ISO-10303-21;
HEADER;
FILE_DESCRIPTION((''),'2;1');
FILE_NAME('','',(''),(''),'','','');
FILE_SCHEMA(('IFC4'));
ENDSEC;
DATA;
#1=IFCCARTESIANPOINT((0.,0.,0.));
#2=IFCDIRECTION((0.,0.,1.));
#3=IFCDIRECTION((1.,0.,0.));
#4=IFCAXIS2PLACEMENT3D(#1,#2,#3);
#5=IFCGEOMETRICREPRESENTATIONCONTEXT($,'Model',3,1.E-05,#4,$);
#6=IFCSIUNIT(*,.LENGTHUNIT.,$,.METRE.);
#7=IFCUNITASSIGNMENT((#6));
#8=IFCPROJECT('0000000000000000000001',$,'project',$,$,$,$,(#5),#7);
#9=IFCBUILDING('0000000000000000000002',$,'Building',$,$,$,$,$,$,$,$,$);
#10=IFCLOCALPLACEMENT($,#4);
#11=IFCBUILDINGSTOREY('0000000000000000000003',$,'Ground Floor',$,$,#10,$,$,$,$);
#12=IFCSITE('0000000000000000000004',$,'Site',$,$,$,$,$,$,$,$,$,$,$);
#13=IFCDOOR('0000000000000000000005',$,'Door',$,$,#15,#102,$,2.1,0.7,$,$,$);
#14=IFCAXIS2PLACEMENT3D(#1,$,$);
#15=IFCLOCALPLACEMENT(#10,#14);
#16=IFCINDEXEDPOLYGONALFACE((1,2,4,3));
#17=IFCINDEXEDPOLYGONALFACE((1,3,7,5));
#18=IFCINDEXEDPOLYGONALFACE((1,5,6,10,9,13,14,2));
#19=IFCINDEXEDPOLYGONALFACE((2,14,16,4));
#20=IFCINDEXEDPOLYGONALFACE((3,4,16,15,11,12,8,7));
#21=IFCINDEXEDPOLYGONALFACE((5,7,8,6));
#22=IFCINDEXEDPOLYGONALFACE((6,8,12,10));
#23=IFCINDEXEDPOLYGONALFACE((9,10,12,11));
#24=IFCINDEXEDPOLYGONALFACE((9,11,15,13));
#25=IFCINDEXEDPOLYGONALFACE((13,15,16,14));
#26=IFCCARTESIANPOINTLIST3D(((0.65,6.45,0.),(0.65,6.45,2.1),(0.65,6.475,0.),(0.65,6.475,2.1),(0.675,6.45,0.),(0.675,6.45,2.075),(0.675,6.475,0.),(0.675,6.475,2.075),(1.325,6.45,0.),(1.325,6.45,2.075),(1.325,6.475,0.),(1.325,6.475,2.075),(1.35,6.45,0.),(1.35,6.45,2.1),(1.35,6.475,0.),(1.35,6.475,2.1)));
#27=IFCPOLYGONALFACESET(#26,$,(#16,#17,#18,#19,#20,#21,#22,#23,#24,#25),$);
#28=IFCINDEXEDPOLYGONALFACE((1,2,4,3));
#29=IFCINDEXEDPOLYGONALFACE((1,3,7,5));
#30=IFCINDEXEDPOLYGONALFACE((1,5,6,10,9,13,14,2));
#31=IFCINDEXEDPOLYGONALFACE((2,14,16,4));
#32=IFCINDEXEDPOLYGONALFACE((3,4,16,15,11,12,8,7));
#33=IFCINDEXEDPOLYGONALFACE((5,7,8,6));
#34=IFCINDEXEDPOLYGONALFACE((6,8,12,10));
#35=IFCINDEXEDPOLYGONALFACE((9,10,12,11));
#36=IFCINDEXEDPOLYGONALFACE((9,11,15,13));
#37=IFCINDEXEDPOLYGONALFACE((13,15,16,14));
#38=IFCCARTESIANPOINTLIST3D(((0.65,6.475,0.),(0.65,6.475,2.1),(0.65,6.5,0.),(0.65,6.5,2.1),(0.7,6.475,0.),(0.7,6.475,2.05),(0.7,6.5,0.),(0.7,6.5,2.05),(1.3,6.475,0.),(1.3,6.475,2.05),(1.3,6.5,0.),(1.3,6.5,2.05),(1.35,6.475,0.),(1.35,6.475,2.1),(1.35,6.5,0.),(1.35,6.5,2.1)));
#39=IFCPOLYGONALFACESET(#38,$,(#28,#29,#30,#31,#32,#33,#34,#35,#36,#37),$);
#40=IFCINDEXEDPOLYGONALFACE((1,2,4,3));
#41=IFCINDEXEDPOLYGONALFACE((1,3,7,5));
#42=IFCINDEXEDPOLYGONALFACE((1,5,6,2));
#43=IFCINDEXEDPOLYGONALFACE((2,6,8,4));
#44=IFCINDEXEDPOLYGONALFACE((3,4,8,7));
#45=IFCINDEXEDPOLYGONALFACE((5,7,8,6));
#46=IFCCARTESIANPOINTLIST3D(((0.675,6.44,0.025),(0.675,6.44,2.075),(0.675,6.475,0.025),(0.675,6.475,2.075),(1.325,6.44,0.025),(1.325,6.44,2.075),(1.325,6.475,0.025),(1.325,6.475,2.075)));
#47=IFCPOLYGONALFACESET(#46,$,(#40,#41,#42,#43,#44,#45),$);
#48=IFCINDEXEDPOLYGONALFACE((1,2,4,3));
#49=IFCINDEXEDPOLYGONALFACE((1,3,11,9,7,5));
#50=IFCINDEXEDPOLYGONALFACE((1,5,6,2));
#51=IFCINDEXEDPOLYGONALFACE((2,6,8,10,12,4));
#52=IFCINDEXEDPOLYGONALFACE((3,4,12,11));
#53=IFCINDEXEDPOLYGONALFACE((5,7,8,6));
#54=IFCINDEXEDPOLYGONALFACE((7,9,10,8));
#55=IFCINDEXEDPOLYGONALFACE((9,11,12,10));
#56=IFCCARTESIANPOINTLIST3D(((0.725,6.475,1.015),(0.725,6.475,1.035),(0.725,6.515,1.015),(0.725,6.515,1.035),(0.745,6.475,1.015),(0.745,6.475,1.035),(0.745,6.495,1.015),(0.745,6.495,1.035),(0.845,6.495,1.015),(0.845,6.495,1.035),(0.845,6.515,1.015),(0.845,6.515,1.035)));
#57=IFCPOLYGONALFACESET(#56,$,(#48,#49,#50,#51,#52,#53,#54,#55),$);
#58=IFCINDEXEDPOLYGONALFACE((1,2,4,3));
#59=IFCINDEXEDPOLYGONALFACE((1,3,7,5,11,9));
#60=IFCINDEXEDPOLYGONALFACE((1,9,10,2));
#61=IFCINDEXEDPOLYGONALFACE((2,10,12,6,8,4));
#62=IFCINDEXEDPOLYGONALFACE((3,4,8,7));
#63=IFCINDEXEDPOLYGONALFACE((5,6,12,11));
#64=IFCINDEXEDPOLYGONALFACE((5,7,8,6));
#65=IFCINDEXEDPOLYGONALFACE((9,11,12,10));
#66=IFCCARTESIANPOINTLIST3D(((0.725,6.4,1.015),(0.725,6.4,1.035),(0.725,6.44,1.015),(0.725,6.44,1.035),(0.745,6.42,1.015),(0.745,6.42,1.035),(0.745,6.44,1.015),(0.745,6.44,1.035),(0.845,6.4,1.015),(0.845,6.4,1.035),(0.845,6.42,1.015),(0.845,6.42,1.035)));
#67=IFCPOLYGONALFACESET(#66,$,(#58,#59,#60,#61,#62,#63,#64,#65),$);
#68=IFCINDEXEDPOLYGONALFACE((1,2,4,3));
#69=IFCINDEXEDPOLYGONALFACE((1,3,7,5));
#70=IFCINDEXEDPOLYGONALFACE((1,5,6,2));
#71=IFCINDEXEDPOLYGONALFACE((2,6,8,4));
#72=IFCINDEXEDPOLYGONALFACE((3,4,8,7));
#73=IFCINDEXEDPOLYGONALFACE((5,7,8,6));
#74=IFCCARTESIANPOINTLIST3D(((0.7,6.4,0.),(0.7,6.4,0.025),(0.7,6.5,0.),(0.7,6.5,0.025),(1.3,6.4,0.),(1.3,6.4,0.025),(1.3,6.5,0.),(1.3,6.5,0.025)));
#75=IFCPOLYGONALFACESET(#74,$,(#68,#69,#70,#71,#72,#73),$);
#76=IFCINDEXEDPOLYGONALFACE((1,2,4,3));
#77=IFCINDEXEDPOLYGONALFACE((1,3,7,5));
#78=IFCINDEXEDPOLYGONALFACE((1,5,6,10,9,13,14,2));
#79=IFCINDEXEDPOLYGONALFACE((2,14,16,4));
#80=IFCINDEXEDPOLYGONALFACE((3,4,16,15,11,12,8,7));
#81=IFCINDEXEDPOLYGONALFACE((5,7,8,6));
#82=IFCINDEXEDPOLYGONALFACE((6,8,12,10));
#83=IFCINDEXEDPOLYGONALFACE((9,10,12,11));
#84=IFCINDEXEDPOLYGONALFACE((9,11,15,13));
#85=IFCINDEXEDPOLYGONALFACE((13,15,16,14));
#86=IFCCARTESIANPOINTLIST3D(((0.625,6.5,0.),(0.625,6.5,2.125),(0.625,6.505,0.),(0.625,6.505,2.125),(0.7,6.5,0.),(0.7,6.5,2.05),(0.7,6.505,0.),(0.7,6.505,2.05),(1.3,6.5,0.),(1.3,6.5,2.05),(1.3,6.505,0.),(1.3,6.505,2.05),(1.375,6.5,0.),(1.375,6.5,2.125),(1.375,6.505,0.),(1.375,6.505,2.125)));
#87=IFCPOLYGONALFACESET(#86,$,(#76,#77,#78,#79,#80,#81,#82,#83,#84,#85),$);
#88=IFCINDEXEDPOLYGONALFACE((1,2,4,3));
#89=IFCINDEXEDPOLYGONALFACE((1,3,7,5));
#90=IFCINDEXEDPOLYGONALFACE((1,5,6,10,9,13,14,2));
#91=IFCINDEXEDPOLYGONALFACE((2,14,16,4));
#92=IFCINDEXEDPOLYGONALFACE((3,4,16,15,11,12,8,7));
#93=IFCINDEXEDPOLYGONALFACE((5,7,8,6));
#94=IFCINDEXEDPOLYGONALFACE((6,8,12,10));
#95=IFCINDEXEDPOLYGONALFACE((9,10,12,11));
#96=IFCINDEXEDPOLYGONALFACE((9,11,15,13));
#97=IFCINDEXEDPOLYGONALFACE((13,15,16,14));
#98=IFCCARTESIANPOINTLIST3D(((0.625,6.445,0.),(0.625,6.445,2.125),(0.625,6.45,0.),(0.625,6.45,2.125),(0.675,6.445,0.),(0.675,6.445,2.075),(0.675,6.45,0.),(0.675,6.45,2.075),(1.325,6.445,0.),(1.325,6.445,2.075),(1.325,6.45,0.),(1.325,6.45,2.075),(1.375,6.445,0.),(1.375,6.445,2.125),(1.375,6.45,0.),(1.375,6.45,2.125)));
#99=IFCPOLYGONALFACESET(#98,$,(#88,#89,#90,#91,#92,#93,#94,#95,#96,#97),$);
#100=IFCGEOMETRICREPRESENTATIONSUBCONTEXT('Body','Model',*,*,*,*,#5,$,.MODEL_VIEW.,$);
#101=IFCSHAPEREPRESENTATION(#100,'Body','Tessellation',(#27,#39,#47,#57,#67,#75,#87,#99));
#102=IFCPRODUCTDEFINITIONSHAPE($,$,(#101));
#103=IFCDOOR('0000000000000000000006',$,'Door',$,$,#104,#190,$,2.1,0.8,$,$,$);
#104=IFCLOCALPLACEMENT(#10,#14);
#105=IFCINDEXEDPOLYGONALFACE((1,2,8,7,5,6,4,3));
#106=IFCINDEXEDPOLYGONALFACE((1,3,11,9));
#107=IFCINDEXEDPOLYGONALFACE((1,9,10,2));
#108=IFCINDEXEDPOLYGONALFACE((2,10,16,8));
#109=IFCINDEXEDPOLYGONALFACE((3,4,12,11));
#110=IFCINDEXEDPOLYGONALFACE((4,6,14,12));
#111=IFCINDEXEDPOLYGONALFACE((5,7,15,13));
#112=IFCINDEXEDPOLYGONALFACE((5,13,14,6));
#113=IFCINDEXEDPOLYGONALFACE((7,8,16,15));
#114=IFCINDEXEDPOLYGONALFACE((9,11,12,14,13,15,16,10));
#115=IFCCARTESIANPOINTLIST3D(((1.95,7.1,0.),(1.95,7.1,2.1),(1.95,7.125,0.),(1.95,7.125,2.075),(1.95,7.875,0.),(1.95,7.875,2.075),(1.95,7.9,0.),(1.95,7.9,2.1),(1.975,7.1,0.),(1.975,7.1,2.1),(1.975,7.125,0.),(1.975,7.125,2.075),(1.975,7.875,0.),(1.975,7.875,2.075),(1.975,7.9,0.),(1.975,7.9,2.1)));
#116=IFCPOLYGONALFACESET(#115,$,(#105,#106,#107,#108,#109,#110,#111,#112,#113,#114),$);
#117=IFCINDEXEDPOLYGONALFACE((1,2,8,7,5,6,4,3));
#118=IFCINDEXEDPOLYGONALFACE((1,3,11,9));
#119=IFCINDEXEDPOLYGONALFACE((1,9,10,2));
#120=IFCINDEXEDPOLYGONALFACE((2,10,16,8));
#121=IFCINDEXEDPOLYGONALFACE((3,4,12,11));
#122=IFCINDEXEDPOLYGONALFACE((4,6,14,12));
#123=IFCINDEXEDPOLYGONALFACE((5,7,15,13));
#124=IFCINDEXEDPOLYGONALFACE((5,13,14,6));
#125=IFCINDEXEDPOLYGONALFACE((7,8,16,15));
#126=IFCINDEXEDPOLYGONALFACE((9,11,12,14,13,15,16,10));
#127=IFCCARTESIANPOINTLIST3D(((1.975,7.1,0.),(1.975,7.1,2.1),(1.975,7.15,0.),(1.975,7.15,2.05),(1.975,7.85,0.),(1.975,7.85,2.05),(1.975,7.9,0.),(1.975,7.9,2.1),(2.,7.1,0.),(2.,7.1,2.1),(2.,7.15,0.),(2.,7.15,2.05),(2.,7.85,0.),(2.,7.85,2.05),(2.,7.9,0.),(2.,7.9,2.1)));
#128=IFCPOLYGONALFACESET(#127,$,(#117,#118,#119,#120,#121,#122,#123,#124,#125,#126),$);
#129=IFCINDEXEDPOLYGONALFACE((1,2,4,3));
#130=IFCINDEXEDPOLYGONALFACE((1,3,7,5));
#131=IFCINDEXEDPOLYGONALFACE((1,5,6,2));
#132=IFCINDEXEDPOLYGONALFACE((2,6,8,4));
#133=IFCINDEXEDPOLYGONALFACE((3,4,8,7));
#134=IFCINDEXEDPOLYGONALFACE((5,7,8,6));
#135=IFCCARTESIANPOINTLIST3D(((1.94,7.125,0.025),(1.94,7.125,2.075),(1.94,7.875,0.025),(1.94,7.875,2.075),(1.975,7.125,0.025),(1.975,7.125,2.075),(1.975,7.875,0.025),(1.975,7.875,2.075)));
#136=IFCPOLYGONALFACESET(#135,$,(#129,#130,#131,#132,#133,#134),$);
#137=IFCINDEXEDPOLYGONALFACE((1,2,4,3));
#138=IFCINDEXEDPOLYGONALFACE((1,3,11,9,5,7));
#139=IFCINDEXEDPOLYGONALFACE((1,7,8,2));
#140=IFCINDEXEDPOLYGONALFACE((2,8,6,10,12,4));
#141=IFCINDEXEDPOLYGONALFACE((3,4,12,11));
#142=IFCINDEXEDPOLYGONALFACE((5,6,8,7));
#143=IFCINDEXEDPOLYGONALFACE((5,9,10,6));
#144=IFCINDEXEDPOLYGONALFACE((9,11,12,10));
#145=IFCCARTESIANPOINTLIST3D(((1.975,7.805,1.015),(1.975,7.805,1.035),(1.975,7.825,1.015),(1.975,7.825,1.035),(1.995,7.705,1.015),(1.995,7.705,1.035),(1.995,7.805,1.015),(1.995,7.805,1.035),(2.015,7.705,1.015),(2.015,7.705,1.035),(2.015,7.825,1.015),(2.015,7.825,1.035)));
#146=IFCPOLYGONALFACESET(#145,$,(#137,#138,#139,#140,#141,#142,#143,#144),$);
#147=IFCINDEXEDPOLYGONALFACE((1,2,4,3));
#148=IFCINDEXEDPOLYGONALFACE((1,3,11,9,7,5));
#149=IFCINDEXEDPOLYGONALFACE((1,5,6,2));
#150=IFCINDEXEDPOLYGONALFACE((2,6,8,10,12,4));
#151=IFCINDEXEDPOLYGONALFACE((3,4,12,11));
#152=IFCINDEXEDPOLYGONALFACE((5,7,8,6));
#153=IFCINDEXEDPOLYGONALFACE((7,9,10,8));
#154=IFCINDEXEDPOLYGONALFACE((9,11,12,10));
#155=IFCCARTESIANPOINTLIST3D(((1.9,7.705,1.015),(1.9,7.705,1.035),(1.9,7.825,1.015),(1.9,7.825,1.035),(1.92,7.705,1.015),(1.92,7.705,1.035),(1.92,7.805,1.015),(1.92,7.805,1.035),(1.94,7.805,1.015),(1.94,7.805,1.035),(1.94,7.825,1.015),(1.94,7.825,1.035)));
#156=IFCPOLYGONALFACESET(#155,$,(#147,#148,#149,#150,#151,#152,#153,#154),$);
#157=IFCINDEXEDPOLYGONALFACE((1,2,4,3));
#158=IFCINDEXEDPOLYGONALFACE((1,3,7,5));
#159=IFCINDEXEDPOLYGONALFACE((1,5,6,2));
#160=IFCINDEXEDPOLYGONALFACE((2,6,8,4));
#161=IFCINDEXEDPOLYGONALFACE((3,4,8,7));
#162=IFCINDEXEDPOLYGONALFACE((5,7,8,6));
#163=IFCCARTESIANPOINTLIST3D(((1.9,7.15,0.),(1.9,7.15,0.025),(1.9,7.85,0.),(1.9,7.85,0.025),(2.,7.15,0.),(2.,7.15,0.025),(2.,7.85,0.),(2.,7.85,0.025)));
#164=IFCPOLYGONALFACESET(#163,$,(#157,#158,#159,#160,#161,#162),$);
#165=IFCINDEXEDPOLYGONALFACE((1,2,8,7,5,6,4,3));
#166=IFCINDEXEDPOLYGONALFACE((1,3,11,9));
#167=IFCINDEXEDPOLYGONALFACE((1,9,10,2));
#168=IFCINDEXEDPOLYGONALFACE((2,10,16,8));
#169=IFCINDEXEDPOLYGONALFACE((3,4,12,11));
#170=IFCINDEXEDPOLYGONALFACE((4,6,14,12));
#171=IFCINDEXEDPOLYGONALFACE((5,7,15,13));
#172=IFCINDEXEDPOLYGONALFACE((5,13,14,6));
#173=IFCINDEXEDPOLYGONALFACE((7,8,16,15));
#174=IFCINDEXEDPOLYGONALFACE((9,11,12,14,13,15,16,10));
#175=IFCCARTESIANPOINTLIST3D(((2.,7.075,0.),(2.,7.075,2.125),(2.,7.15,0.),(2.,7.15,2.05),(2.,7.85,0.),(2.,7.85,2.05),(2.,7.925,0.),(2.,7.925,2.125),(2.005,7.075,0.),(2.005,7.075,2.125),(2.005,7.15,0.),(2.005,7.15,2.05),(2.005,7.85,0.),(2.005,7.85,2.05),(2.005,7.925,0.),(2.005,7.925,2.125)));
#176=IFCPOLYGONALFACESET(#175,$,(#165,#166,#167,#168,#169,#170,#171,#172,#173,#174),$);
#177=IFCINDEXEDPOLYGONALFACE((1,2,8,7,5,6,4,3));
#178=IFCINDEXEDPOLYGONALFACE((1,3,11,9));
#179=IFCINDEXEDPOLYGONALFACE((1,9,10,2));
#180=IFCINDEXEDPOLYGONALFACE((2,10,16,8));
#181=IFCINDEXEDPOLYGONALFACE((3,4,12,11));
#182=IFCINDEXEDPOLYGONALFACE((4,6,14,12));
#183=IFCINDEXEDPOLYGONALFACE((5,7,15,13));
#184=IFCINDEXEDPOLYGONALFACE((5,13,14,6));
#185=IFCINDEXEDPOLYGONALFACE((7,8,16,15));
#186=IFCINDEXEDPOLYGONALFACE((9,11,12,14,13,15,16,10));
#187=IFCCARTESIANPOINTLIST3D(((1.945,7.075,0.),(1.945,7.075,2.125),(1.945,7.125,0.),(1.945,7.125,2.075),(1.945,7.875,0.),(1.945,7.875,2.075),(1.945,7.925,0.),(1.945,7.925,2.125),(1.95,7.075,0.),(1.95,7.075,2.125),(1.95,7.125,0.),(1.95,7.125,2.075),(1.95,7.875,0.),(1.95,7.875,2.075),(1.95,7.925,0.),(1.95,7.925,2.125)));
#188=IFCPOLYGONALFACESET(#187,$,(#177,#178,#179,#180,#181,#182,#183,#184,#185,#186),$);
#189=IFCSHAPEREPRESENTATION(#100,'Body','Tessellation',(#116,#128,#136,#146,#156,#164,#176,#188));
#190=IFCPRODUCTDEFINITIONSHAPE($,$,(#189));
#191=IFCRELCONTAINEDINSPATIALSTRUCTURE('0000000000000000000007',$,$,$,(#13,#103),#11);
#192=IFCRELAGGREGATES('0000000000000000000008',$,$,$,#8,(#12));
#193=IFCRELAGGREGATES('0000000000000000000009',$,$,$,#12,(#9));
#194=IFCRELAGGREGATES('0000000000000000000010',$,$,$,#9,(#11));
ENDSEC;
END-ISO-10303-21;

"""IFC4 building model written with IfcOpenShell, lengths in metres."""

from ifc_helpers import new_model, si_unit, frame, origin_with_axes, place, context, subcontext, project, spatial, line, indexed_curve, outline, extrude, element, save


model = new_model("IFC4")

# Units and contexts
model_context = context("Model", 3, precision=1e-05, world=origin_with_axes())
body_context = subcontext(model_context, "Body", "Model", "MODEL_VIEW")
ifc_project = project(units=[si_unit("LENGTHUNIT", "METRE")], contexts=[model_context])

# Site, building, storey
site = spatial("IfcSite", under=ifc_project, Name="Site")
building = spatial("IfcBuilding", under=site, Name="Building")
storey_placement = place(None, origin_with_axes())
storey = spatial("IfcBuildingStorey", under=building, at=storey_placement, Name="Ground Floor")

# Doors
door_1_placement = place(storey_placement, frame((1.35, 6.5, 0.0), z_axis=(0.0, 0.0, 1.0), x_axis=(-1.0, 0.0, 0.0)))
element("IfcDoor", 1, at=door_1_placement, inside=storey, Name="Door", OverallHeight=2.1, OverallWidth=0.7, context=body_context, shape_type="SweptSolid", body=[
    extrude(outline(indexed_curve([(0.0, 0.0), (0.0, 2.1), (0.7, 2.1), (0.7, 0.0), (0.675, 0.0), (0.675, 2.075), (0.025, 2.075), (0.025, 0.0)], segments=[line(1, 2, 3, 4, 5, 6, 7, 8, 1)])), frame((0.0, 0.025, 0.0), z_axis=(0.0, -1.0, 0.0), x_axis=(1.0, 0.0, 0.0)), (0.0, 0.0, -1.0), 0.025),
    extrude(outline(indexed_curve([(0.0, 0.0), (0.0, 2.1), (0.7, 2.1), (0.7, 0.0), (0.65, 0.0), (0.65, 2.05), (0.05, 2.05), (0.05, 0.0)], segments=[line(1, 2, 3, 4, 5, 6, 7, 8, 1)])), frame((0.0, 0.0, 0.0), z_axis=(0.0, -1.0, 0.0), x_axis=(1.0, 0.0, 0.0)), (0.0, 0.0, -1.0), 0.025),
    extrude(outline(indexed_curve([(0.0, 0.0), (0.65, 0.0), (0.65, 0.035), (0.0, 0.035)], segments=[line(1, 2, 3, 4, 1)])), frame((0.025, 0.025, 0.025), z_axis=(0.0, 0.0, 1.0), x_axis=(1.0, 0.0, 0.0)), (0.0, 0.0, 1.0), 2.05),
    extrude(outline(indexed_curve([(0.0, 0.0), (0.0, -0.04), (-0.12, -0.04), (-0.12, -0.02), (-0.02, -0.02), (-0.02, 0.0)], segments=[line(1, 2, 3, 4, 5, 6, 1)])), frame((0.625, 0.025, 1.015), z_axis=(0.0, 0.0, 1.0), x_axis=(1.0, 0.0, 0.0)), (0.0, 0.0, 1.0), 0.02),
    extrude(outline(indexed_curve([(0.0, 0.0), (0.0, 0.04), (-0.12, 0.04), (-0.12, 0.02), (-0.02, 0.02), (-0.02, 0.0)], segments=[line(1, 2, 3, 4, 5, 6, 1)])), frame((0.625, 0.06, 1.015), z_axis=(0.0, 0.0, 1.0), x_axis=(1.0, 0.0, 0.0)), (0.0, 0.0, 1.0), 0.02),
    extrude(outline(indexed_curve([(0.0, 0.0), (0.6, 0.0), (0.6, 0.1), (0.0, 0.1)], segments=[line(1, 2, 3, 4, 1)])), frame((0.05, 0.0, 0.0), z_axis=(0.0, 0.0, 1.0), x_axis=(1.0, 0.0, 0.0)), (0.0, 0.0, 1.0), 0.025),
    extrude(outline(indexed_curve([(0.0, 0.0), (0.0, 2.125), (0.75, 2.125), (0.75, 0.0), (0.675, 0.0), (0.675, 2.05), (0.075, 2.05), (0.075, 0.0)], segments=[line(1, 2, 3, 4, 5, 6, 7, 8, 1)])), frame((-0.025, -0.005, 0.0), z_axis=(0.0, -1.0, 0.0), x_axis=(1.0, 0.0, 0.0)), (0.0, 0.0, -1.0), 0.005),
    extrude(outline(indexed_curve([(0.0, 0.0), (0.0, 2.125), (0.75, 2.125), (0.75, 0.0), (0.7, 0.0), (0.7, 2.075), (0.05, 2.075), (0.05, 0.0)], segments=[line(1, 2, 3, 4, 5, 6, 7, 8, 1)])), frame((-0.025, 0.05, 0.0), z_axis=(0.0, -1.0, 0.0), x_axis=(1.0, 0.0, 0.0)), (0.0, 0.0, -1.0), 0.005),
])
door_2_placement = place(storey_placement, frame((2.0, 7.1, 0.0), z_axis=(0.0, 0.0, 1.0), x_axis=(0.0, 1.0, 0.0)))
element("IfcDoor", 2, at=door_2_placement, inside=storey, Name="Door", OverallHeight=2.1, OverallWidth=0.8, context=body_context, shape_type="SweptSolid", body=[
    extrude(outline(indexed_curve([(0.0, 0.0), (0.0, 2.1), (0.8, 2.1), (0.8, 0.0), (0.775, 0.0), (0.775, 2.075), (0.025, 2.075), (0.025, 0.0)], segments=[line(1, 2, 3, 4, 5, 6, 7, 8, 1)])), frame((0.0, 0.025, 0.0), z_axis=(0.0, -1.0, 0.0), x_axis=(1.0, 0.0, 0.0)), (0.0, 0.0, -1.0), 0.025),
    extrude(outline(indexed_curve([(0.0, 0.0), (0.0, 2.1), (0.8, 2.1), (0.8, 0.0), (0.75, 0.0), (0.75, 2.05), (0.05, 2.05), (0.05, 0.0)], segments=[line(1, 2, 3, 4, 5, 6, 7, 8, 1)])), frame((0.0, 0.0, 0.0), z_axis=(0.0, -1.0, 0.0), x_axis=(1.0, 0.0, 0.0)), (0.0, 0.0, -1.0), 0.025),
    extrude(outline(indexed_curve([(0.0, 0.0), (0.75, 0.0), (0.75, 0.035), (0.0, 0.035)], segments=[line(1, 2, 3, 4, 1)])), frame((0.025, 0.025, 0.025), z_axis=(0.0, 0.0, 1.0), x_axis=(1.0, 0.0, 0.0)), (0.0, 0.0, 1.0), 2.05),
    extrude(outline(indexed_curve([(0.0, 0.0), (0.0, -0.04), (-0.12, -0.04), (-0.12, -0.02), (-0.02, -0.02), (-0.02, 0.0)], segments=[line(1, 2, 3, 4, 5, 6, 1)])), frame((0.725, 0.025, 1.015), z_axis=(0.0, 0.0, 1.0), x_axis=(1.0, 0.0, 0.0)), (0.0, 0.0, 1.0), 0.02),
    extrude(outline(indexed_curve([(0.0, 0.0), (0.0, 0.04), (-0.12, 0.04), (-0.12, 0.02), (-0.02, 0.02), (-0.02, 0.0)], segments=[line(1, 2, 3, 4, 5, 6, 1)])), frame((0.725, 0.06, 1.015), z_axis=(0.0, 0.0, 1.0), x_axis=(1.0, 0.0, 0.0)), (0.0, 0.0, 1.0), 0.02),
    extrude(outline(indexed_curve([(0.0, 0.0), (0.7, 0.0), (0.7, 0.1), (0.0, 0.1)], segments=[line(1, 2, 3, 4, 1)])), frame((0.05, 0.0, 0.0), z_axis=(0.0, 0.0, 1.0), x_axis=(1.0, 0.0, 0.0)), (0.0, 0.0, 1.0), 0.025),
    extrude(outline(indexed_curve([(0.0, 0.0), (0.0, 2.125), (0.85, 2.125), (0.85, 0.0), (0.775, 0.0), (0.775, 2.05), (0.075, 2.05), (0.075, 0.0)], segments=[line(1, 2, 3, 4, 5, 6, 7, 8, 1)])), frame((-0.025, -0.005, 0.0), z_axis=(0.0, -1.0, 0.0), x_axis=(1.0, 0.0, 0.0)), (0.0, 0.0, -1.0), 0.005),
    extrude(outline(indexed_curve([(0.0, 0.0), (0.0, 2.125), (0.85, 2.125), (0.85, 0.0), (0.8, 0.0), (0.8, 2.075), (0.05, 2.075), (0.05, 0.0)], segments=[line(1, 2, 3, 4, 5, 6, 7, 8, 1)])), frame((-0.025, 0.05, 0.0), z_axis=(0.0, -1.0, 0.0), x_axis=(1.0, 0.0, 0.0)), (0.0, 0.0, -1.0), 0.005),
])

save(model, "model.ifc")
